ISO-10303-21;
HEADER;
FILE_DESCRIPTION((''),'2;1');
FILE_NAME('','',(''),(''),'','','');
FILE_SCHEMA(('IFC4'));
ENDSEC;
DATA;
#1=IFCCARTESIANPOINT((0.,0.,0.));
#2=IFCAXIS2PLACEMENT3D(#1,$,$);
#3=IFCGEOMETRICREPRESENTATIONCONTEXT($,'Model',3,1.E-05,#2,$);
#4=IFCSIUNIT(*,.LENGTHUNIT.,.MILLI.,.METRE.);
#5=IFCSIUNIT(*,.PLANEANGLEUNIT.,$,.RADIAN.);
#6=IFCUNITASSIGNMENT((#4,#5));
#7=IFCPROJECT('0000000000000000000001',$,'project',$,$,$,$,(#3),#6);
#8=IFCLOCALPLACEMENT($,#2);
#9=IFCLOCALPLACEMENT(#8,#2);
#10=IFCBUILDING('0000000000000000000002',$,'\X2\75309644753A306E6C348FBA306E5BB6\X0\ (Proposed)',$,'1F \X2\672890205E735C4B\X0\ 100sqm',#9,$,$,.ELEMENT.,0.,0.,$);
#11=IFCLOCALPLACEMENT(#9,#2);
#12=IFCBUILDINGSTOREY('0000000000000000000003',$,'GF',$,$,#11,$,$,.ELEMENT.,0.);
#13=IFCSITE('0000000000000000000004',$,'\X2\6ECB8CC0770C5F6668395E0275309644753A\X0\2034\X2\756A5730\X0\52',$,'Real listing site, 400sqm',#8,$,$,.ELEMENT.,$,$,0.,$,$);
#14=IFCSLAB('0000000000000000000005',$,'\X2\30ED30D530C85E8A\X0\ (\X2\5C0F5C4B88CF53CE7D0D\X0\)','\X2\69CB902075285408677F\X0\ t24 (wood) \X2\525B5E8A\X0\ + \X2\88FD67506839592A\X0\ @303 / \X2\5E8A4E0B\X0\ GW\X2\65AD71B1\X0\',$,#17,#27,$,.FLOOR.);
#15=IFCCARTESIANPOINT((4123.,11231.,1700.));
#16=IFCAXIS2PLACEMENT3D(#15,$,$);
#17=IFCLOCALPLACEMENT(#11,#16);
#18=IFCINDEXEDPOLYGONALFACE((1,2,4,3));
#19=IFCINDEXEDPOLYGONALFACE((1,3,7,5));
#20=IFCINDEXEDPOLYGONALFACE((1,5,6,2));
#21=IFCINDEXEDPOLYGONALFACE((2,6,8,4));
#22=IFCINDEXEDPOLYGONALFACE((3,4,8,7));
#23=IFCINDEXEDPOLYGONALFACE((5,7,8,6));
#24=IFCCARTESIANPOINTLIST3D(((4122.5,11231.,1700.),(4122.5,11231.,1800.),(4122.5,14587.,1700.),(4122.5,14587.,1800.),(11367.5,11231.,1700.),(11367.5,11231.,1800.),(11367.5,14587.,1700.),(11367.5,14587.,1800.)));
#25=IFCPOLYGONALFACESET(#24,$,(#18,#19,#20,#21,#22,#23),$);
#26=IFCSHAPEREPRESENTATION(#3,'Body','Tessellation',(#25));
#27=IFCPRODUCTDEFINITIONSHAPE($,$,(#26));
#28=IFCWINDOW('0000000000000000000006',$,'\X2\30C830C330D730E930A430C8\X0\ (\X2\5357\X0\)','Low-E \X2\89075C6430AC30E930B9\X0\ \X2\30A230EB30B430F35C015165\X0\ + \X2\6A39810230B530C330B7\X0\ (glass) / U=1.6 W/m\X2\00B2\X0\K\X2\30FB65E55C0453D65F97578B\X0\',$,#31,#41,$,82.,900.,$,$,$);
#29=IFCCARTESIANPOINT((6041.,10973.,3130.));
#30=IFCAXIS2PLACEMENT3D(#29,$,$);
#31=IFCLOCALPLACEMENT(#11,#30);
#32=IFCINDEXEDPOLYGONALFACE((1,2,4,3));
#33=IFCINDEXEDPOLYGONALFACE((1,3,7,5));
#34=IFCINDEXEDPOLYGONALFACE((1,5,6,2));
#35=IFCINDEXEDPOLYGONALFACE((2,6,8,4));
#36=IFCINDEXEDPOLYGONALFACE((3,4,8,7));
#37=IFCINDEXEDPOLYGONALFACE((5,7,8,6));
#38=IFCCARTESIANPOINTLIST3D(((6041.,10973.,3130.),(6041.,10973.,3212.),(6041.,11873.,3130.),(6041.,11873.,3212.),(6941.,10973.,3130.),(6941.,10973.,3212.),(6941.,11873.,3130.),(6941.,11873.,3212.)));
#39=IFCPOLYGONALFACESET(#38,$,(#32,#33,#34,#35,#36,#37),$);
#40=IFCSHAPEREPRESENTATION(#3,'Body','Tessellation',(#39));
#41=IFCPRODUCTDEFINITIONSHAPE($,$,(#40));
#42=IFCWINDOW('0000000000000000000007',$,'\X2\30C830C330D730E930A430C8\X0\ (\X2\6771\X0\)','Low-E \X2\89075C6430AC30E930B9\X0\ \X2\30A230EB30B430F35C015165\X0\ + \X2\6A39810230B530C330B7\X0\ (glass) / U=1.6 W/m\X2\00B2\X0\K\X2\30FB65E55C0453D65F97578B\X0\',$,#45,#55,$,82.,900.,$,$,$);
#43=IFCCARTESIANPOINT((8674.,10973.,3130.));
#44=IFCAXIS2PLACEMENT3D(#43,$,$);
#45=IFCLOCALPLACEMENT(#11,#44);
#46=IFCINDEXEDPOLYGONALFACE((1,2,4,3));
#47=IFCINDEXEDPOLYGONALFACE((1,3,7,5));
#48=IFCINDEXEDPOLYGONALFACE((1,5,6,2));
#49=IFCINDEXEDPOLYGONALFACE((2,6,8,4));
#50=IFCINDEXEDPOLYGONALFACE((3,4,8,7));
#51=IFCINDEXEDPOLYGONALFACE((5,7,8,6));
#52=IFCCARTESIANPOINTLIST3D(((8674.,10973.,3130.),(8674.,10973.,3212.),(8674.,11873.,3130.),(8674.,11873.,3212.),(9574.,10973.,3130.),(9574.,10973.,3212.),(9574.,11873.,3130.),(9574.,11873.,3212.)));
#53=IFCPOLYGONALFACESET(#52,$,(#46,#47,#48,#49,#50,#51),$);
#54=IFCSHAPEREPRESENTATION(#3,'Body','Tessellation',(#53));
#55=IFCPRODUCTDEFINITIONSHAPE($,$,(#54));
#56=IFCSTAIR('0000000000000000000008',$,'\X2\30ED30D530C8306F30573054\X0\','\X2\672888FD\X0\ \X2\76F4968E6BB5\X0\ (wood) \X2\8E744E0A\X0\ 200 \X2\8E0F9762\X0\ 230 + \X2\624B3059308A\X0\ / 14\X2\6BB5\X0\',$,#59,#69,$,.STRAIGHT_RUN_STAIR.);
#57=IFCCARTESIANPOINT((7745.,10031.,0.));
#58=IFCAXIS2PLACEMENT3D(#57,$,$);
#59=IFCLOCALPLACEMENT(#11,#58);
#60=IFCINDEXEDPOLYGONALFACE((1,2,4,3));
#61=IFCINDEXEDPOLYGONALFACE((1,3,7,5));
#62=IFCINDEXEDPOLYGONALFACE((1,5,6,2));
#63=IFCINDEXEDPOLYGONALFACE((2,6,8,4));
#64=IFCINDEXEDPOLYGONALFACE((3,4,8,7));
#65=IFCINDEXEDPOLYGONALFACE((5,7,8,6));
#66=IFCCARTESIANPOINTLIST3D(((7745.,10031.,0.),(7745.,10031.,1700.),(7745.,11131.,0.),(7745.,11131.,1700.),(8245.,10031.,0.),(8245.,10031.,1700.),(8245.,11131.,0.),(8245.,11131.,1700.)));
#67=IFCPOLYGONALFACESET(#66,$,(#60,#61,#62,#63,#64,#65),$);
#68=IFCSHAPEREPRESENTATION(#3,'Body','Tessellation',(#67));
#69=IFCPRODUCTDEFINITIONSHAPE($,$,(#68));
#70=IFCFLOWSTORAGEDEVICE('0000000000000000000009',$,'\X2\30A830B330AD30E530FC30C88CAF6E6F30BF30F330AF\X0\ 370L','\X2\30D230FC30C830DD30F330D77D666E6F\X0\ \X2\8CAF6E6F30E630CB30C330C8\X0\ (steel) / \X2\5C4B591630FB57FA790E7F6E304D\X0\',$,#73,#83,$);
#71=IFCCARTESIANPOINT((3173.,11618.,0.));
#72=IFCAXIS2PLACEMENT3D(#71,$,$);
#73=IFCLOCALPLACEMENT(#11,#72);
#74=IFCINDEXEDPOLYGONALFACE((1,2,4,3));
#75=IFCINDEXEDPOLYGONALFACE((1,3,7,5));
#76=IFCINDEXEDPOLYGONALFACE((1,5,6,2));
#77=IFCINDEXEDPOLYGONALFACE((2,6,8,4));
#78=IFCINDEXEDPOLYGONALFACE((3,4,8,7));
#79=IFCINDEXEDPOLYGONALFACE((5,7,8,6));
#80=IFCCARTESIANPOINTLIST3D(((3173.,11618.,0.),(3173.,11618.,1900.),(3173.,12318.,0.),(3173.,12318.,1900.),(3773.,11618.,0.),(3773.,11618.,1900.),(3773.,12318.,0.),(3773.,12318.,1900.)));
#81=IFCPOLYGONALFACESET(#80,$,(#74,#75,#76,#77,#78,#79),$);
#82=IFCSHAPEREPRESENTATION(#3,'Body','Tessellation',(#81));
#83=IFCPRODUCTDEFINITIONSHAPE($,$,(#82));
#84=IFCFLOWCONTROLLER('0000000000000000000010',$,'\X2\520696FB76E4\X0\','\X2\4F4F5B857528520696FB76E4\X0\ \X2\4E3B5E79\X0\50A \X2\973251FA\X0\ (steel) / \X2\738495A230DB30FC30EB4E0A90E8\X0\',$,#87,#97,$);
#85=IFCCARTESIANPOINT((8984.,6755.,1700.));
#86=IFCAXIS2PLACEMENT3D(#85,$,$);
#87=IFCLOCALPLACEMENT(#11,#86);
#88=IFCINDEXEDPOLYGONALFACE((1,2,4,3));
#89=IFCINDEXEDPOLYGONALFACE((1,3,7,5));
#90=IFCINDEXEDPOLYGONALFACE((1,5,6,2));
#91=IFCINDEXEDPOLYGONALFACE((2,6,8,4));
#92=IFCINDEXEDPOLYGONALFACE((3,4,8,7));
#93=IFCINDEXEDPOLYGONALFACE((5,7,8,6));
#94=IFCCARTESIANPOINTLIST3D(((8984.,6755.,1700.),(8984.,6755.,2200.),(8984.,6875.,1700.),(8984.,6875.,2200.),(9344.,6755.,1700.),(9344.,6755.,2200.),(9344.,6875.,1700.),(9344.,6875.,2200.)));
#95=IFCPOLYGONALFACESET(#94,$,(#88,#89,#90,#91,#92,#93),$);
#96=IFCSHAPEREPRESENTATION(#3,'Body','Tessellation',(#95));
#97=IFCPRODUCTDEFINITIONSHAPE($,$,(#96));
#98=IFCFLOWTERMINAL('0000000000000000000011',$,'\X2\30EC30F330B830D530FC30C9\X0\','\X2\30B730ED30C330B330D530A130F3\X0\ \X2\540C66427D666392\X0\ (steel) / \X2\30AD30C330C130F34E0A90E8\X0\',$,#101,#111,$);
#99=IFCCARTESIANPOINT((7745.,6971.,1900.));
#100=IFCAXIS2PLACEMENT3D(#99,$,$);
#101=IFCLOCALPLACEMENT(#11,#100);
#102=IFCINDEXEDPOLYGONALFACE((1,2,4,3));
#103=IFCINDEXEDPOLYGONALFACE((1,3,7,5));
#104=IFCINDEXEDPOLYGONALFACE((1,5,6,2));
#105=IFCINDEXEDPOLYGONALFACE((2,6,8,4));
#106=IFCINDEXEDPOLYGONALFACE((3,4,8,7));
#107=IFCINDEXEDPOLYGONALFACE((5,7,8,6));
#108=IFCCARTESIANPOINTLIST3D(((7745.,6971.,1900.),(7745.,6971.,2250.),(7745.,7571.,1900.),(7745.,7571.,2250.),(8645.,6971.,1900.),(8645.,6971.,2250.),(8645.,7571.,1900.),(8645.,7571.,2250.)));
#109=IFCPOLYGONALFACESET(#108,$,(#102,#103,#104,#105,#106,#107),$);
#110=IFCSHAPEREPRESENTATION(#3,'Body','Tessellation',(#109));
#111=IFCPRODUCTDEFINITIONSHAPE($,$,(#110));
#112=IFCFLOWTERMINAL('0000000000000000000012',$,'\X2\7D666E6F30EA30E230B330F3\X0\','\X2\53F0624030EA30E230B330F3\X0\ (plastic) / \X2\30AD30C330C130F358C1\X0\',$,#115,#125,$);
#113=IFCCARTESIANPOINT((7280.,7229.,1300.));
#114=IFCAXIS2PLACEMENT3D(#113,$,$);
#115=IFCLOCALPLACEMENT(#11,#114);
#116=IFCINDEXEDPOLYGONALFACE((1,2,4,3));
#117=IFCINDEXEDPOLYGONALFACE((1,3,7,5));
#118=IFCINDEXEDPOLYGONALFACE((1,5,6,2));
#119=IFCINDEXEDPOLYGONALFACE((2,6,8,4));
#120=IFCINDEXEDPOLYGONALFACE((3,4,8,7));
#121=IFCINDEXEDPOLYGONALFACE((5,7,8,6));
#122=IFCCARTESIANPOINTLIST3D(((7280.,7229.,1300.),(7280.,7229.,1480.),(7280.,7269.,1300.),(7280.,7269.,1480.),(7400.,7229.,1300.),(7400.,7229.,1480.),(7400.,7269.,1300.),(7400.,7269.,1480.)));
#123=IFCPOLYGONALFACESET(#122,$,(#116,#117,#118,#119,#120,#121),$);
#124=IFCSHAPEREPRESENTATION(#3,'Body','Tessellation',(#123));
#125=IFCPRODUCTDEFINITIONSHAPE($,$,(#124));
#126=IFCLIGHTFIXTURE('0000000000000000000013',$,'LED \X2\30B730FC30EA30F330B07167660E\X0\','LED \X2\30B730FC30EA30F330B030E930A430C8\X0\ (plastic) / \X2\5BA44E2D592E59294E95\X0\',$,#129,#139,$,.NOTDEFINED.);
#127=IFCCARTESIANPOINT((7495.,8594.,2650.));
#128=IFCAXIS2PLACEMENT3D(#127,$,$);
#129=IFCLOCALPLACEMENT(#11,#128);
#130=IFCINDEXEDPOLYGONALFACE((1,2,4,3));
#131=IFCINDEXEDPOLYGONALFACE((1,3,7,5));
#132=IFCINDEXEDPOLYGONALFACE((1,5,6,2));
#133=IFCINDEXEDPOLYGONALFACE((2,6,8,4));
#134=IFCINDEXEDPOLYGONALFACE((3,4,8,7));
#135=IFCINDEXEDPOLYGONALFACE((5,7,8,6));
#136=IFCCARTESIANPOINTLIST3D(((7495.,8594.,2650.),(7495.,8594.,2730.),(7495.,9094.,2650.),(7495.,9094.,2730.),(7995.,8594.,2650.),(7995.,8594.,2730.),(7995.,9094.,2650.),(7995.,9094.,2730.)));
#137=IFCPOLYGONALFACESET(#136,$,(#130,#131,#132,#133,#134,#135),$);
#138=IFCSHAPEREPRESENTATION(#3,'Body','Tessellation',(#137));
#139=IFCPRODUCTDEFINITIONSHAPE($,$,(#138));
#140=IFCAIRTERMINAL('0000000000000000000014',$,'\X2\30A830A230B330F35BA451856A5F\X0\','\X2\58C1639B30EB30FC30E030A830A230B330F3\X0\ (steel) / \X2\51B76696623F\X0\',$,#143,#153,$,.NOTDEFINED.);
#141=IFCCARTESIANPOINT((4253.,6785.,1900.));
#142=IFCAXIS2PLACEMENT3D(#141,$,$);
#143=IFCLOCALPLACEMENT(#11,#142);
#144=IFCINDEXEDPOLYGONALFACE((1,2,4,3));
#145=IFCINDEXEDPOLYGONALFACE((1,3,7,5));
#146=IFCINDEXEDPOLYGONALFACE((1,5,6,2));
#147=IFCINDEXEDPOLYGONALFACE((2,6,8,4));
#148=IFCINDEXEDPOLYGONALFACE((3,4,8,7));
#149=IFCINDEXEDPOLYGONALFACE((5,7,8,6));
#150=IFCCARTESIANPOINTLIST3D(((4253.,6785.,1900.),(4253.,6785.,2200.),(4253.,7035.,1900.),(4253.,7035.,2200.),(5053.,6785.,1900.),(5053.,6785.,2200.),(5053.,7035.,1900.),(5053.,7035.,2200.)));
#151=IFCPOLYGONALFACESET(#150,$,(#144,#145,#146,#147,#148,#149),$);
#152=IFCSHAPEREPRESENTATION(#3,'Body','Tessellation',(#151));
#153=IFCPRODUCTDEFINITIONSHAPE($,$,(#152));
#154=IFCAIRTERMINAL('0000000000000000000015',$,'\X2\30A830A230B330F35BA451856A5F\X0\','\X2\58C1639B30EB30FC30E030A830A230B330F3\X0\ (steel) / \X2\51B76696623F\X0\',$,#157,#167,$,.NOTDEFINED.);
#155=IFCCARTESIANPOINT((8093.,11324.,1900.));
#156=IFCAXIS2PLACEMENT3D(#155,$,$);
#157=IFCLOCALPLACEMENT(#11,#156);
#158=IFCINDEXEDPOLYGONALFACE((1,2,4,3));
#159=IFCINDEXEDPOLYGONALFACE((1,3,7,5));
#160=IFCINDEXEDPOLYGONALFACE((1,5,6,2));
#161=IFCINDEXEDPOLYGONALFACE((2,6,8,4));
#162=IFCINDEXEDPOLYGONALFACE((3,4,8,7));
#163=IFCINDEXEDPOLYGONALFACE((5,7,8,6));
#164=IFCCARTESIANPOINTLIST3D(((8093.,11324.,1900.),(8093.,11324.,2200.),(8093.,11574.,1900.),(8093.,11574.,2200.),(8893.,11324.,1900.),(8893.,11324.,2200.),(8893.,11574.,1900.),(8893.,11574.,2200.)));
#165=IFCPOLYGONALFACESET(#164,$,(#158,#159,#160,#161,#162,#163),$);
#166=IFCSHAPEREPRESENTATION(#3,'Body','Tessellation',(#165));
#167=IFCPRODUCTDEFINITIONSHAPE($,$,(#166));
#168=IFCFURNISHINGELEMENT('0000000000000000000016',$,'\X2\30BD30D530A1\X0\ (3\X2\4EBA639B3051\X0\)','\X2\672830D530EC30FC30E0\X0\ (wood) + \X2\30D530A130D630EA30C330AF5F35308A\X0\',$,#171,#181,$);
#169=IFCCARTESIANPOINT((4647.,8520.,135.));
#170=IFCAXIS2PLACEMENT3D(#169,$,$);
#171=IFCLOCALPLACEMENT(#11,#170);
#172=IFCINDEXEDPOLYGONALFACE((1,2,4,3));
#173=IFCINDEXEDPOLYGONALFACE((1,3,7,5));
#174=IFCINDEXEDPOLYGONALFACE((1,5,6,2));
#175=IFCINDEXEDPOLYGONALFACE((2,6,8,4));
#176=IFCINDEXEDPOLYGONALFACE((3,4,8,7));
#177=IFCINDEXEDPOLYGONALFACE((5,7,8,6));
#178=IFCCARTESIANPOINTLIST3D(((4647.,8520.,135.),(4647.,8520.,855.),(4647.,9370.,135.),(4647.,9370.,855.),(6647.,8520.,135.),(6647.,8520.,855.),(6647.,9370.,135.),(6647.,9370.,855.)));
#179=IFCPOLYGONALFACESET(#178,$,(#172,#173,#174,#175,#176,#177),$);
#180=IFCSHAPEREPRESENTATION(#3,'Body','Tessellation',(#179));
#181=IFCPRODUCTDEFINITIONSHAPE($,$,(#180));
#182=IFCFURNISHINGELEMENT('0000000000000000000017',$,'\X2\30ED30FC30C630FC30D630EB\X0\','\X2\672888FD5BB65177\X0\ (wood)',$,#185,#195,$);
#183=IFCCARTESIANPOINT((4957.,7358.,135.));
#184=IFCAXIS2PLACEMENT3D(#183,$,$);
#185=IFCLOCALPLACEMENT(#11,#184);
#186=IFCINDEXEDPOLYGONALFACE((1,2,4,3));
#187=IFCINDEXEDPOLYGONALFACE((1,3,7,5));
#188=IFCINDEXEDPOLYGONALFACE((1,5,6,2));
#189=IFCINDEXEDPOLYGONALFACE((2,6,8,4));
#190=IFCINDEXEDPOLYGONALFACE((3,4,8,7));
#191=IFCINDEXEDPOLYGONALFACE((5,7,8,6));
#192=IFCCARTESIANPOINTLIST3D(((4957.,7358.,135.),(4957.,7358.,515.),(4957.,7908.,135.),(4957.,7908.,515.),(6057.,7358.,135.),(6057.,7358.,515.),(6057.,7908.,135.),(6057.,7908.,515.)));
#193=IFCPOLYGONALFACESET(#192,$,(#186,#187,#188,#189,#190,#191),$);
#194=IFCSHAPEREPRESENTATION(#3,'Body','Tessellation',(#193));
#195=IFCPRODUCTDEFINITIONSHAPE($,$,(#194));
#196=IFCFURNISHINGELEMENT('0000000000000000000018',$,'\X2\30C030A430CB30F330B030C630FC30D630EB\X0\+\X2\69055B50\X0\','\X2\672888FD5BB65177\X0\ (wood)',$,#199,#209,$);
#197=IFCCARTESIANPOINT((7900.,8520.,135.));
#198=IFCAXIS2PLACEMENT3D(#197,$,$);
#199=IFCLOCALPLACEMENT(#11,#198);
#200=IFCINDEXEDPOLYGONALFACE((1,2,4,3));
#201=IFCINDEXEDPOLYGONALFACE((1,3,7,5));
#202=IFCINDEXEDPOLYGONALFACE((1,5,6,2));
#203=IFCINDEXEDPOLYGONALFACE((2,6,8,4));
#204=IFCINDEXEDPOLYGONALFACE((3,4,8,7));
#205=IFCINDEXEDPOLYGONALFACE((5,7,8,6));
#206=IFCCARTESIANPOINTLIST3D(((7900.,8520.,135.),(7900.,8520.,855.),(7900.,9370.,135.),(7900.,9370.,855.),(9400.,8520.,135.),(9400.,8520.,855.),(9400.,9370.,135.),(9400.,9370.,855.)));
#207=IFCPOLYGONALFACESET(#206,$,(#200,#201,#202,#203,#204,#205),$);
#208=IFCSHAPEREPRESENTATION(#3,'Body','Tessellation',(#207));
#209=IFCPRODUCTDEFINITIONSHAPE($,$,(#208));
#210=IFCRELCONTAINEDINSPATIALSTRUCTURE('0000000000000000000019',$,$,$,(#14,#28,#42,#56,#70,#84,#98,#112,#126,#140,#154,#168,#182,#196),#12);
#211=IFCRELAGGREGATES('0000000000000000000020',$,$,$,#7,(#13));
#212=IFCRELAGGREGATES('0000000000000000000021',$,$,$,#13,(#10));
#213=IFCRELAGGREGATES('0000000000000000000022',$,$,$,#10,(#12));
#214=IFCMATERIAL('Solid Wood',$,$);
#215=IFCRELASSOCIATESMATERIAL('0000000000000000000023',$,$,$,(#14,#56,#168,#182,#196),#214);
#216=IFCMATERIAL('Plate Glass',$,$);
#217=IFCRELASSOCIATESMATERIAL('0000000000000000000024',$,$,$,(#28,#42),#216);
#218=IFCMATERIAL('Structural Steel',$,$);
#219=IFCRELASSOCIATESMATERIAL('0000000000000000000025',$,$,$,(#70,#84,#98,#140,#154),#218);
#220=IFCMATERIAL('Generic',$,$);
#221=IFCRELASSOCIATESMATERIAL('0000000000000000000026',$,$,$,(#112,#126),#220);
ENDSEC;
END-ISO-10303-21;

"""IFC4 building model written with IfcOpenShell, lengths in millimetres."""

from ifc_helpers import new_model, si_unit, frame, frame_2d, origin, place, context, project, spatial, rectangle, extrude, material, element, save


model = new_model("IFC4")

# Units and contexts
model_context = context("Model", 3, precision=1e-05, world=origin())
ifc_project = project(units=[si_unit("LENGTHUNIT", "METRE", prefix="MILLI"), si_unit("PLANEANGLEUNIT", "RADIAN")], contexts=[model_context])

# Site, building, storey
site_placement = place(None, origin())
site = spatial("IfcSite", under=ifc_project, at=site_placement, Name="滋賀県彦根市田附町2034番地52", ObjectType="Real listing site, 400sqm", CompositionType="ELEMENT", RefElevation=0.0)
building_placement = place(site_placement, origin())
building = spatial("IfcBuilding", under=site, at=building_placement, Name="田附町の水辺の家 (Proposed)", ObjectType="1F 木造平屋 100sqm", CompositionType="ELEMENT", ElevationOfRefHeight=0.0, ElevationOfTerrain=0.0)
storey_placement = place(building_placement, origin())
storey = spatial("IfcBuildingStorey", under=building, at=storey_placement, Name="GF", CompositionType="ELEMENT", Elevation=0.0)

# Shared definitions
ifc_material_1 = material(Name="Solid Wood")

# Slab
slab_placement = place(storey_placement, frame((4123.0, 11231.0, 1700.0)))
element("IfcSlab", 1, at=slab_placement, inside=storey, material=ifc_material_1, Name="ロフト床 (小屋裏収納)", Description="構造用合板 t24 (wood) 剛床 + 製材根太 @303 / 床下 GW断熱", PredefinedType="FLOOR", context=model_context, shape_type="SweptSolid", body=[
    extrude(rectangle(XDim=7245.0, YDim=3356.0, at=frame_2d((3622.0, 1678.0))), frame((4123.0, 11231.0, 1700.0)), (0.0, 0.0, 1.0), 100.0),
])

# Windows
ifc_material_2 = material(Name="Plate Glass")
window_1_placement = place(storey_placement, frame((6041.0, 10973.0, 3130.0)))
element("IfcWindow", 2, at=window_1_placement, inside=storey, material=ifc_material_2, Name="トップライト (南)", Description="Low-E 複層ガラス アルゴン封入 + 樹脂サッシ (glass) / U=1.6 W/m²K・日射取得型", OverallHeight=82.0, OverallWidth=900.0, context=model_context, shape_type="SweptSolid", body=[
    extrude(rectangle(XDim=900.0, YDim=900.0, at=frame_2d((450.0, 450.0))), frame((6041.0, 10973.0, 3130.0)), (0.0, 0.0, 1.0), 82.0),
])
window_2_placement = place(storey_placement, frame((8674.0, 10973.0, 3130.0)))
element("IfcWindow", 3, at=window_2_placement, inside=storey, material=ifc_material_2, Name="トップライト (東)", Description="Low-E 複層ガラス アルゴン封入 + 樹脂サッシ (glass) / U=1.6 W/m²K・日射取得型", OverallHeight=82.0, OverallWidth=900.0, context=model_context, shape_type="SweptSolid", body=[
    extrude(rectangle(XDim=900.0, YDim=900.0, at=frame_2d((450.0, 450.0))), frame((8674.0, 10973.0, 3130.0)), (0.0, 0.0, 1.0), 82.0),
])

# Stair
stair_placement = place(storey_placement, frame((7745.0, 10031.0, 0.0)))
element("IfcStair", 4, at=stair_placement, inside=storey, material=ifc_material_1, Name="ロフトはしご", Description="木製 直階段 (wood) 蹴上 200 踏面 230 + 手すり / 14段", PredefinedType="STRAIGHT_RUN_STAIR", context=model_context, shape_type="SweptSolid", body=[
    extrude(rectangle(XDim=500.0, YDim=1100.0, at=frame_2d((250.0, 550.0))), frame((7745.0, 10031.0, 0.0)), (0.0, 0.0, 1.0), 1700.0),
])

# Flow storage device
ifc_material_3 = material(Name="Structural Steel")
flow_storage_device_placement = place(storey_placement, frame((3173.0, 11618.0, 0.0)))
element("IfcFlowStorageDevice", 5, at=flow_storage_device_placement, inside=storey, material=ifc_material_3, Name="エコキュート貯湯タンク 370L", Description="ヒートポンプ給湯 貯湯ユニット (steel) / 屋外・基礎置き", context=model_context, shape_type="SweptSolid", body=[
    extrude(rectangle(XDim=600.0, YDim=700.0, at=frame_2d((300.0, 350.0))), frame((3173.0, 11618.0, 0.0)), (0.0, 0.0, 1.0), 1900.0),
])

# Flow controller
flow_controller_placement = place(storey_placement, frame((8984.0, 6755.0, 1700.0)))
element("IfcFlowController", 6, at=flow_controller_placement, inside=storey, material=ifc_material_3, Name="分電盤", Description="住宅用分電盤 主幹50A 露出 (steel) / 玄関ホール上部", context=model_context, shape_type="SweptSolid", body=[
    extrude(rectangle(XDim=360.0, YDim=120.0, at=frame_2d((180.0, 60.0))), frame((8984.0, 6755.0, 1700.0)), (0.0, 0.0, 1.0), 500.0),
])

# Flow terminals
flow_terminal_1_placement = place(storey_placement, frame((7745.0, 6971.0, 1900.0)))
element("IfcFlowTerminal", 7, at=flow_terminal_1_placement, inside=storey, material=ifc_material_3, Name="レンジフード", Description="シロッコファン 同時給排 (steel) / キッチン上部", context=model_context, shape_type="SweptSolid", body=[
    extrude(rectangle(XDim=900.0, YDim=600.0, at=frame_2d((450.0, 300.0))), frame((7745.0, 6971.0, 1900.0)), (0.0, 0.0, 1.0), 350.0),
])
ifc_material_4 = material(Name="Generic")
flow_terminal_2_placement = place(storey_placement, frame((7280.0, 7229.0, 1300.0)))
element("IfcFlowTerminal", 8, at=flow_terminal_2_placement, inside=storey, material=ifc_material_4, Name="給湯リモコン", Description="台所リモコン (plastic) / キッチン壁", context=model_context, shape_type="SweptSolid", body=[
    extrude(rectangle(XDim=120.0, YDim=40.0, at=frame_2d((60.0, 20.0))), frame((7280.0, 7229.0, 1300.0)), (0.0, 0.0, 1.0), 180.0),
])

# Light fixture
light_fixture_placement = place(storey_placement, frame((7495.0, 8594.0, 2650.0)))
element("IfcLightFixture", 9, at=light_fixture_placement, inside=storey, material=ifc_material_4, Name="LED シーリング照明", Description="LED シーリングライト (plastic) / 室中央天井", PredefinedType="NOTDEFINED", context=model_context, shape_type="SweptSolid", body=[
    extrude(rectangle(XDim=500.0, YDim=500.0, at=frame_2d((250.0, 250.0))), frame((7495.0, 8594.0, 2650.0)), (0.0, 0.0, 1.0), 80.0),
])

# Air terminals
air_terminal_1_placement = place(storey_placement, frame((4253.0, 6785.0, 1900.0)))
element("IfcAirTerminal", 10, at=air_terminal_1_placement, inside=storey, material=ifc_material_3, Name="エアコン室内機", Description="壁掛ルームエアコン (steel) / 冷暖房", PredefinedType="NOTDEFINED", context=model_context, shape_type="SweptSolid", body=[
    extrude(rectangle(XDim=800.0, YDim=250.0, at=frame_2d((400.0, 125.0))), frame((4253.0, 6785.0, 1900.0)), (0.0, 0.0, 1.0), 300.0),
])
air_terminal_2_placement = place(storey_placement, frame((8093.0, 11324.0, 1900.0)))
element("IfcAirTerminal", 11, at=air_terminal_2_placement, inside=storey, material=ifc_material_3, Name="エアコン室内機", Description="壁掛ルームエアコン (steel) / 冷暖房", PredefinedType="NOTDEFINED", context=model_context, shape_type="SweptSolid", body=[
    extrude(rectangle(XDim=800.0, YDim=250.0, at=frame_2d((400.0, 125.0))), frame((8093.0, 11324.0, 1900.0)), (0.0, 0.0, 1.0), 300.0),
])

# Furnishing elements
furnishing_1_placement = place(storey_placement, frame((4647.0, 8520.0, 135.0)))
element("IfcFurnishingElement", 12, at=furnishing_1_placement, inside=storey, material=ifc_material_1, Name="ソファ (3人掛け)", Description="木フレーム (wood) + ファブリック張り", context=model_context, shape_type="SweptSolid", body=[
    extrude(rectangle(XDim=2000.0, YDim=850.0, at=frame_2d((1000.0, 425.0))), frame((4647.0, 8520.0, 135.0)), (0.0, 0.0, 1.0), 720.0),
])
furnishing_2_placement = place(storey_placement, frame((4957.0, 7358.0, 135.0)))
element("IfcFurnishingElement", 13, at=furnishing_2_placement, inside=storey, material=ifc_material_1, Name="ローテーブル", Description="木製家具 (wood)", context=model_context, shape_type="SweptSolid", body=[
    extrude(rectangle(XDim=1100.0, YDim=550.0, at=frame_2d((550.0, 275.0))), frame((4957.0, 7358.0, 135.0)), (0.0, 0.0, 1.0), 380.0),
])
furnishing_3_placement = place(storey_placement, frame((7900.0, 8520.0, 135.0)))
element("IfcFurnishingElement", 14, at=furnishing_3_placement, inside=storey, material=ifc_material_1, Name="ダイニングテーブル+椅子", Description="木製家具 (wood)", context=model_context, shape_type="SweptSolid", body=[
    extrude(rectangle(XDim=1500.0, YDim=850.0, at=frame_2d((750.0, 425.0))), frame((7900.0, 8520.0, 135.0)), (0.0, 0.0, 1.0), 720.0),
])

save(model, "model.ifc")
